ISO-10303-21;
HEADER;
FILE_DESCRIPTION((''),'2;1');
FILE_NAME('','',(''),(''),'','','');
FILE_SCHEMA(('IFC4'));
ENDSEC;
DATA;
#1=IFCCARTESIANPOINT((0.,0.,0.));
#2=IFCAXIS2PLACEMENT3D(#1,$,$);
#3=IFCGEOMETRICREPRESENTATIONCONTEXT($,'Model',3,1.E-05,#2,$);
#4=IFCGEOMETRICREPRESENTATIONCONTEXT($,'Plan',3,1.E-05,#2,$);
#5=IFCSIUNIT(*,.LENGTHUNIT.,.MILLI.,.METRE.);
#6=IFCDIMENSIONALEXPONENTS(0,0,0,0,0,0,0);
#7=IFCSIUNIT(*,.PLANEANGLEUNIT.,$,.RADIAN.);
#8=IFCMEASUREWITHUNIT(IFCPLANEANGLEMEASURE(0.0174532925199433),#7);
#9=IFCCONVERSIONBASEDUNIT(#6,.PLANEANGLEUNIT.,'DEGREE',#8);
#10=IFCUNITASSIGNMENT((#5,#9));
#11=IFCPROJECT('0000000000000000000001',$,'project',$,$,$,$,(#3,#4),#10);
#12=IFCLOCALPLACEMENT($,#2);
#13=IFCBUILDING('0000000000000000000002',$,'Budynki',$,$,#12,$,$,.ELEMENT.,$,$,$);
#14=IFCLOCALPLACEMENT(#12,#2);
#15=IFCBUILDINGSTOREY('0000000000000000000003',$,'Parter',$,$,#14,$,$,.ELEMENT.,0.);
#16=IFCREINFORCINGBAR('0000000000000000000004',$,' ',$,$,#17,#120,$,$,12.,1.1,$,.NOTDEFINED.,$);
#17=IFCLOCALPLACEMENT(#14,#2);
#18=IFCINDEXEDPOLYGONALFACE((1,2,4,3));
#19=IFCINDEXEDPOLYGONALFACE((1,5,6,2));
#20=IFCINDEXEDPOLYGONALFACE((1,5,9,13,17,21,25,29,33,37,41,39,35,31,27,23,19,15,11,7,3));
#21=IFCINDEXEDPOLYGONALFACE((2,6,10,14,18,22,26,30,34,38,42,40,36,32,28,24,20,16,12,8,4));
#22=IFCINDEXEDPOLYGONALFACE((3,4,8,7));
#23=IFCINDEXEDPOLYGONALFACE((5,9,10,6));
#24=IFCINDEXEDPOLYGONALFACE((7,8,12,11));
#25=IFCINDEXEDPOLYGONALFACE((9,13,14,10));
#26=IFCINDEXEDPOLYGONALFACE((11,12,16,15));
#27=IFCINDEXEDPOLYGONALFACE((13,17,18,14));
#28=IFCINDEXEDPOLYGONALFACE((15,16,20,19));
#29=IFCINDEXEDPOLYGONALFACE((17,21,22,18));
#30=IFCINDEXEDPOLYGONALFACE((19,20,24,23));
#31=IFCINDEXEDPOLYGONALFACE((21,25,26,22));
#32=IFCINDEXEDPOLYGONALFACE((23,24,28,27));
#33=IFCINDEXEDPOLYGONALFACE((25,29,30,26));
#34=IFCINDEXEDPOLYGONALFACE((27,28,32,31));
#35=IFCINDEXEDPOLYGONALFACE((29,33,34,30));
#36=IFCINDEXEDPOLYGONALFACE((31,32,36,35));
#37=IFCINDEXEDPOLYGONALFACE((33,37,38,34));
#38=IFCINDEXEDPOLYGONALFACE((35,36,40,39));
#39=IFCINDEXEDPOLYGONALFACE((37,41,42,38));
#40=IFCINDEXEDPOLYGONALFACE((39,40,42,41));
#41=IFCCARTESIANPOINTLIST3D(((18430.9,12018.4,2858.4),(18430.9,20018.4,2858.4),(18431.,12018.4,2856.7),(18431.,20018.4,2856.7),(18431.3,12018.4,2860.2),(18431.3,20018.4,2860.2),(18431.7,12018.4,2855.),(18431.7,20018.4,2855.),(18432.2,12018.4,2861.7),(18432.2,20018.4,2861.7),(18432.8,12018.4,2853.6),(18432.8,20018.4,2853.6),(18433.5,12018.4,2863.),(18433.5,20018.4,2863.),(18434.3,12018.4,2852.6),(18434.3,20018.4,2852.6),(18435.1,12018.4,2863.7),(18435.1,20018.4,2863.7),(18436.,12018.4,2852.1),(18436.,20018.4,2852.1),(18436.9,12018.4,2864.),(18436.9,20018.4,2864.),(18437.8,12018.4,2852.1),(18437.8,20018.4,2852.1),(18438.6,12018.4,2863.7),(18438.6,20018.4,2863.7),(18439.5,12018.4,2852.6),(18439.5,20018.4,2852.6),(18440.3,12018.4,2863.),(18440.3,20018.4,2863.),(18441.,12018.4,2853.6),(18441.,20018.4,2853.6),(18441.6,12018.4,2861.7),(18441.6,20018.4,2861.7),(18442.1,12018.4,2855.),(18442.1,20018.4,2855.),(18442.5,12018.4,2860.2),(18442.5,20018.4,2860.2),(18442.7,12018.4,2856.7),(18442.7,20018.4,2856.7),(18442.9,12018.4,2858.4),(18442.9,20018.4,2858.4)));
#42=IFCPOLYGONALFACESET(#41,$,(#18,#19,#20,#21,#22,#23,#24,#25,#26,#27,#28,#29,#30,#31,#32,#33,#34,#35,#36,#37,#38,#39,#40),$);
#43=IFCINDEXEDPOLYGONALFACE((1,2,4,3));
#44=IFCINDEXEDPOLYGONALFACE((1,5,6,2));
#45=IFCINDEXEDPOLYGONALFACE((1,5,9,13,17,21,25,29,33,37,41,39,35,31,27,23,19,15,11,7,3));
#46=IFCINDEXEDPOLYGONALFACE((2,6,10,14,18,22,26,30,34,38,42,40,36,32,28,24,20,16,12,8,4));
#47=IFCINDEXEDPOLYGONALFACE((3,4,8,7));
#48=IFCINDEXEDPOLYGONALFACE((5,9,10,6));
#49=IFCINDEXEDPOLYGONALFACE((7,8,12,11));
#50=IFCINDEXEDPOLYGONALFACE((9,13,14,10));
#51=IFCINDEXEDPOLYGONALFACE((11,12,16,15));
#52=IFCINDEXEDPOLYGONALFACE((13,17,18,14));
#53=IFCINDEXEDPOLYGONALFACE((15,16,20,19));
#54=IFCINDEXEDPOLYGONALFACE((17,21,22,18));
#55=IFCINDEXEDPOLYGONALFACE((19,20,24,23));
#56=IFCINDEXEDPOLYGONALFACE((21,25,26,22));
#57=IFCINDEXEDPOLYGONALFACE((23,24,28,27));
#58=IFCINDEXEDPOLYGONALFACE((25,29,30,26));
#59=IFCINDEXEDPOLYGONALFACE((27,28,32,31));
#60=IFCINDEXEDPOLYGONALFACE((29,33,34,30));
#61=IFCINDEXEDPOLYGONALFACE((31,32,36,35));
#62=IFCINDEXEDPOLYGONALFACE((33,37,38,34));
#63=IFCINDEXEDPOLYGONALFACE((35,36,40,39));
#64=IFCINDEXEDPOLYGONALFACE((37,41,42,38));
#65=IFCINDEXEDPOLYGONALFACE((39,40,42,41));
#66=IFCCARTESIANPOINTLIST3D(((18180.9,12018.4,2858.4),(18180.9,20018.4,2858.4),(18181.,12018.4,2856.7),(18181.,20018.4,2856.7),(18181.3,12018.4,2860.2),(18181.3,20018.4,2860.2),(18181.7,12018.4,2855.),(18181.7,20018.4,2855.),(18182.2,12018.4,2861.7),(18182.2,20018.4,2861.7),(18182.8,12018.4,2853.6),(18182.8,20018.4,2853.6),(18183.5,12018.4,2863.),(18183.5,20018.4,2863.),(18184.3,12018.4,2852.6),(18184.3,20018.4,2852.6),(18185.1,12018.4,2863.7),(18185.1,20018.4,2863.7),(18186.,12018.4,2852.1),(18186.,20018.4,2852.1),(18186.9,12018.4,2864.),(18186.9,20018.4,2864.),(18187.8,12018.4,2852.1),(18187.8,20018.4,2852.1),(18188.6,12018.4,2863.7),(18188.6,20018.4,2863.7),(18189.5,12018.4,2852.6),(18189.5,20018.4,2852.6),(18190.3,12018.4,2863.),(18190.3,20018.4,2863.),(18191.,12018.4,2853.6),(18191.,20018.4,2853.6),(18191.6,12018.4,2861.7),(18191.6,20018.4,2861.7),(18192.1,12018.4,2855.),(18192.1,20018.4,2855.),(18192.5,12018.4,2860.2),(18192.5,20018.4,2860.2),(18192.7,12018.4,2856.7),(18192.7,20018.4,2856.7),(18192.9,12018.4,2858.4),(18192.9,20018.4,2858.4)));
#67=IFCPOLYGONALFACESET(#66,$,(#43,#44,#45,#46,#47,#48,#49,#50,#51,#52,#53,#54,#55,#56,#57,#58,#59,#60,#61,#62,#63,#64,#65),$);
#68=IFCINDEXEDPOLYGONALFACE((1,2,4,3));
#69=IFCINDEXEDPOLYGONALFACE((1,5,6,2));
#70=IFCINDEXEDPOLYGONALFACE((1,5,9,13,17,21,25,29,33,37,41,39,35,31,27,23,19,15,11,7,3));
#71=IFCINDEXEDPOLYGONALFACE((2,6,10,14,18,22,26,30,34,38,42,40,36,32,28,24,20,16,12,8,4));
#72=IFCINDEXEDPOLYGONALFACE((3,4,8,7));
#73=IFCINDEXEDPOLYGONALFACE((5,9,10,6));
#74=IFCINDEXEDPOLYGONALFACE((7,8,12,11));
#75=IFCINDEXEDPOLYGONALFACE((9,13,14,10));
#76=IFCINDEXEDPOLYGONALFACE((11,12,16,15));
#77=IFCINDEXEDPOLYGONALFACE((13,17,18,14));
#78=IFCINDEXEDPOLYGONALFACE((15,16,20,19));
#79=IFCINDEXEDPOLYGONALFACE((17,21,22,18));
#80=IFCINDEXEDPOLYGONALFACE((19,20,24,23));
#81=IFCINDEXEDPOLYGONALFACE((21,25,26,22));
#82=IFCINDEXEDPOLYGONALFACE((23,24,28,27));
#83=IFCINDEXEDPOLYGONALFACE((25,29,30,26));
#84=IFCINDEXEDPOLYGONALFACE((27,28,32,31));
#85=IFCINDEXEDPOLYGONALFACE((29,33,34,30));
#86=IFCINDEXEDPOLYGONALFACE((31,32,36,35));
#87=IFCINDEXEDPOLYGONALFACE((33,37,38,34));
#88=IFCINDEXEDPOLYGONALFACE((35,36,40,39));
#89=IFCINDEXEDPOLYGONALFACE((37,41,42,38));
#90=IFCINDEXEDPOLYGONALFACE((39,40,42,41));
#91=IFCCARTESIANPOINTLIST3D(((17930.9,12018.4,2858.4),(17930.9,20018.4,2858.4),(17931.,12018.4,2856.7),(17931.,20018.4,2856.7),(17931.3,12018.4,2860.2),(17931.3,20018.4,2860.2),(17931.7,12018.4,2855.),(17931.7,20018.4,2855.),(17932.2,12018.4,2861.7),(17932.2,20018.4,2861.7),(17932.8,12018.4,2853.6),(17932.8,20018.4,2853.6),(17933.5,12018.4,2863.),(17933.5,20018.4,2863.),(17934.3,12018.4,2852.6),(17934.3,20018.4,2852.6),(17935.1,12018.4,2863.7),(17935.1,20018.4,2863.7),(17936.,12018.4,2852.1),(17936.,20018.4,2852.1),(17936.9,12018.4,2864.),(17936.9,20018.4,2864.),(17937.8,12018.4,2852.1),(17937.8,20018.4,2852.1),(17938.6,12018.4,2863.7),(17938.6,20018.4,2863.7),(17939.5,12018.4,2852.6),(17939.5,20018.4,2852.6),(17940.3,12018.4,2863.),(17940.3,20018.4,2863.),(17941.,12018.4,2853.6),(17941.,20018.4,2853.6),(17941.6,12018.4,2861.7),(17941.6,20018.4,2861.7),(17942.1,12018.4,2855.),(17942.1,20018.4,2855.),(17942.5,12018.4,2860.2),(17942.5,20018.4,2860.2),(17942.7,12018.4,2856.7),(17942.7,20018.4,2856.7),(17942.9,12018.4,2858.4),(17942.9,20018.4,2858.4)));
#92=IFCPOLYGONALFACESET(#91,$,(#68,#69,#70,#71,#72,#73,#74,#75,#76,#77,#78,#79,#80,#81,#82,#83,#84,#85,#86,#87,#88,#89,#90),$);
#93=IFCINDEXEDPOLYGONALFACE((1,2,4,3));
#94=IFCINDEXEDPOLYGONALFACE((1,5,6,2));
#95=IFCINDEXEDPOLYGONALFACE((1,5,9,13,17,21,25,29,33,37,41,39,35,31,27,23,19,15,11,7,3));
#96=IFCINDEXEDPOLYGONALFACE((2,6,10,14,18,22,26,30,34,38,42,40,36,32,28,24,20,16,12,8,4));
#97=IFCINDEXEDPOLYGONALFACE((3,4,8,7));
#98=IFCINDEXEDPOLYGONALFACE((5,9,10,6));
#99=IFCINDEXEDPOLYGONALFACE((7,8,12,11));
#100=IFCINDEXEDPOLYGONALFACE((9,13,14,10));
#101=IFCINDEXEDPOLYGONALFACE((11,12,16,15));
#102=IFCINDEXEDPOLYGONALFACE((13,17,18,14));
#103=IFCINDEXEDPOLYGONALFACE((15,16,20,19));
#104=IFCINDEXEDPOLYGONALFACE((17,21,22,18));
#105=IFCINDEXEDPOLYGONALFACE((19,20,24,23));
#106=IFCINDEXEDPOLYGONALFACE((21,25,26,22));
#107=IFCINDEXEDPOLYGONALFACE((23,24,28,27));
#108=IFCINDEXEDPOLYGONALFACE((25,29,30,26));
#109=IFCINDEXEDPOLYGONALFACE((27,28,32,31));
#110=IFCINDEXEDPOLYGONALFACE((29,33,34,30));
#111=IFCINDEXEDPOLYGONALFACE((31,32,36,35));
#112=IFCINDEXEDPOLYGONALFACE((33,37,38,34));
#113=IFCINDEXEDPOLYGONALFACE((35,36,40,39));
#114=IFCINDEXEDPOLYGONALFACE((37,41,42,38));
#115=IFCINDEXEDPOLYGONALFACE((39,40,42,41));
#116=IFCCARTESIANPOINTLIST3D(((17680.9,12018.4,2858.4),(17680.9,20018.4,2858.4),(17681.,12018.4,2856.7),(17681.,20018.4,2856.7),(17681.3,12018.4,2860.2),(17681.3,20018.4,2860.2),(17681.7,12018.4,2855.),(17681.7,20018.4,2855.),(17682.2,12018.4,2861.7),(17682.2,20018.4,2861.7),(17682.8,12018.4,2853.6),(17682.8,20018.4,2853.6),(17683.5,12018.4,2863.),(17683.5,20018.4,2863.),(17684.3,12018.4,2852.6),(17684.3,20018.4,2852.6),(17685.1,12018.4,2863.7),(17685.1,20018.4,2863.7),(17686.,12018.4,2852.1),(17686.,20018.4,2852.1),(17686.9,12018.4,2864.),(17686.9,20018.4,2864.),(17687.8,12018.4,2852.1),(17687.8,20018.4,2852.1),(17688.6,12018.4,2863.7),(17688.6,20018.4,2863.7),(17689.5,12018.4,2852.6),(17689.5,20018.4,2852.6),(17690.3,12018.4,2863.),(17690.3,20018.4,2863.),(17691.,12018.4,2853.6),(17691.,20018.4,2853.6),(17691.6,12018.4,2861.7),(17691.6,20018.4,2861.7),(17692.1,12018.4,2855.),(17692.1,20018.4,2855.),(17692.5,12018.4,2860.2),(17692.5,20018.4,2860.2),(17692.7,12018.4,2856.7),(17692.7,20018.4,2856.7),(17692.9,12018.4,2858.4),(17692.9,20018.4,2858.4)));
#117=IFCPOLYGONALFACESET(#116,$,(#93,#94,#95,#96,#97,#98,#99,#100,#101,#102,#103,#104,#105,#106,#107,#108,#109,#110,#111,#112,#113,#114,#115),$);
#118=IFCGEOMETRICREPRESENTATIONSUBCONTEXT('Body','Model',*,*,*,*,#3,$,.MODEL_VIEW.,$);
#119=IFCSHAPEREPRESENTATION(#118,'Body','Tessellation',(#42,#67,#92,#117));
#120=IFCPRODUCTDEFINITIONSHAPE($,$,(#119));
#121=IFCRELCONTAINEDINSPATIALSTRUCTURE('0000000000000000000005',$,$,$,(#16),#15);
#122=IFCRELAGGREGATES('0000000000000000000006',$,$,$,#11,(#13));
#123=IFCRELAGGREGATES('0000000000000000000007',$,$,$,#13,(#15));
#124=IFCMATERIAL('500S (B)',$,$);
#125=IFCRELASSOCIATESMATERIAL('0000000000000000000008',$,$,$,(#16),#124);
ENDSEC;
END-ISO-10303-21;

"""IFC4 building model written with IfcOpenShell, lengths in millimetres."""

from ifc_helpers import new_model, entity, si_unit, converted_unit, frame, origin, place, context, subcontext, project, spatial, material, element, save


model = new_model("IFC4")

# Units and contexts
model_context = context("Model", 3, precision=1e-05, world=origin())
plan_context = context("Plan", 3, precision=1e-05, world=origin())
body_context = subcontext(model_context, "Body", "Model", "MODEL_VIEW")
ifc_project = project(units=[si_unit("LENGTHUNIT", "METRE", prefix="MILLI"), converted_unit("PLANEANGLEUNIT", "DEGREE", entity("IfcPlaneAngleMeasure", 0.0174532925199433), si_unit("PLANEANGLEUNIT", "RADIAN"), dimensions=[0, 0, 0, 0, 0, 0, 0])], contexts=[model_context, plan_context])

# Building, storey
building_placement = place(None, origin())
building = spatial("IfcBuilding", under=ifc_project, at=building_placement, Name="Budynki", CompositionType="ELEMENT")
storey_placement = place(building_placement, origin())
storey = spatial("IfcBuildingStorey", under=building, at=storey_placement, Name="Parter", CompositionType="ELEMENT", Elevation=0.0)

# Reinforcing bar
ifc_material_1 = material(Name="500S (B)")
reinforcing_bar_1_placement = place(storey_placement, frame((18436.9, 12018.4, 2858.0)))
element("IfcReinforcingBar", 1, at=reinforcing_bar_1_placement, inside=storey, material=ifc_material_1, Name=" ", CrossSectionArea=1.1, NominalDiameter=12.0, PredefinedType="NOTDEFINED", context=body_context, shape_type="AdvancedSweptSolid", body=[
    entity("IfcSweptDiskSolid", entity("IfcPolyline", [entity("IfcCartesianPoint", [0.0, 0.0, 0.0]), entity("IfcCartesianPoint", [0.0, 8000.0, 0.0])]), 6.0, None, 0.0, 1.0),
    entity("IfcSweptDiskSolid", entity("IfcPolyline", [entity("IfcCartesianPoint", [-250.0, 0.0, 0.0]), entity("IfcCartesianPoint", [-250.0, 8000.0, 0.0])]), 6.0, None, 0.0, 1.0),
    entity("IfcSweptDiskSolid", entity("IfcPolyline", [entity("IfcCartesianPoint", [-500.0, 0.0, 0.0]), entity("IfcCartesianPoint", [-500.0, 8000.0, 0.0])]), 6.0, None, 0.0, 1.0),
    entity("IfcSweptDiskSolid", entity("IfcPolyline", [entity("IfcCartesianPoint", [-750.0, 0.0, 0.0]), entity("IfcCartesianPoint", [-750.0, 8000.0, 0.0])]), 6.0, None, 0.0, 1.0),
])

save(model, "model.ifc")
